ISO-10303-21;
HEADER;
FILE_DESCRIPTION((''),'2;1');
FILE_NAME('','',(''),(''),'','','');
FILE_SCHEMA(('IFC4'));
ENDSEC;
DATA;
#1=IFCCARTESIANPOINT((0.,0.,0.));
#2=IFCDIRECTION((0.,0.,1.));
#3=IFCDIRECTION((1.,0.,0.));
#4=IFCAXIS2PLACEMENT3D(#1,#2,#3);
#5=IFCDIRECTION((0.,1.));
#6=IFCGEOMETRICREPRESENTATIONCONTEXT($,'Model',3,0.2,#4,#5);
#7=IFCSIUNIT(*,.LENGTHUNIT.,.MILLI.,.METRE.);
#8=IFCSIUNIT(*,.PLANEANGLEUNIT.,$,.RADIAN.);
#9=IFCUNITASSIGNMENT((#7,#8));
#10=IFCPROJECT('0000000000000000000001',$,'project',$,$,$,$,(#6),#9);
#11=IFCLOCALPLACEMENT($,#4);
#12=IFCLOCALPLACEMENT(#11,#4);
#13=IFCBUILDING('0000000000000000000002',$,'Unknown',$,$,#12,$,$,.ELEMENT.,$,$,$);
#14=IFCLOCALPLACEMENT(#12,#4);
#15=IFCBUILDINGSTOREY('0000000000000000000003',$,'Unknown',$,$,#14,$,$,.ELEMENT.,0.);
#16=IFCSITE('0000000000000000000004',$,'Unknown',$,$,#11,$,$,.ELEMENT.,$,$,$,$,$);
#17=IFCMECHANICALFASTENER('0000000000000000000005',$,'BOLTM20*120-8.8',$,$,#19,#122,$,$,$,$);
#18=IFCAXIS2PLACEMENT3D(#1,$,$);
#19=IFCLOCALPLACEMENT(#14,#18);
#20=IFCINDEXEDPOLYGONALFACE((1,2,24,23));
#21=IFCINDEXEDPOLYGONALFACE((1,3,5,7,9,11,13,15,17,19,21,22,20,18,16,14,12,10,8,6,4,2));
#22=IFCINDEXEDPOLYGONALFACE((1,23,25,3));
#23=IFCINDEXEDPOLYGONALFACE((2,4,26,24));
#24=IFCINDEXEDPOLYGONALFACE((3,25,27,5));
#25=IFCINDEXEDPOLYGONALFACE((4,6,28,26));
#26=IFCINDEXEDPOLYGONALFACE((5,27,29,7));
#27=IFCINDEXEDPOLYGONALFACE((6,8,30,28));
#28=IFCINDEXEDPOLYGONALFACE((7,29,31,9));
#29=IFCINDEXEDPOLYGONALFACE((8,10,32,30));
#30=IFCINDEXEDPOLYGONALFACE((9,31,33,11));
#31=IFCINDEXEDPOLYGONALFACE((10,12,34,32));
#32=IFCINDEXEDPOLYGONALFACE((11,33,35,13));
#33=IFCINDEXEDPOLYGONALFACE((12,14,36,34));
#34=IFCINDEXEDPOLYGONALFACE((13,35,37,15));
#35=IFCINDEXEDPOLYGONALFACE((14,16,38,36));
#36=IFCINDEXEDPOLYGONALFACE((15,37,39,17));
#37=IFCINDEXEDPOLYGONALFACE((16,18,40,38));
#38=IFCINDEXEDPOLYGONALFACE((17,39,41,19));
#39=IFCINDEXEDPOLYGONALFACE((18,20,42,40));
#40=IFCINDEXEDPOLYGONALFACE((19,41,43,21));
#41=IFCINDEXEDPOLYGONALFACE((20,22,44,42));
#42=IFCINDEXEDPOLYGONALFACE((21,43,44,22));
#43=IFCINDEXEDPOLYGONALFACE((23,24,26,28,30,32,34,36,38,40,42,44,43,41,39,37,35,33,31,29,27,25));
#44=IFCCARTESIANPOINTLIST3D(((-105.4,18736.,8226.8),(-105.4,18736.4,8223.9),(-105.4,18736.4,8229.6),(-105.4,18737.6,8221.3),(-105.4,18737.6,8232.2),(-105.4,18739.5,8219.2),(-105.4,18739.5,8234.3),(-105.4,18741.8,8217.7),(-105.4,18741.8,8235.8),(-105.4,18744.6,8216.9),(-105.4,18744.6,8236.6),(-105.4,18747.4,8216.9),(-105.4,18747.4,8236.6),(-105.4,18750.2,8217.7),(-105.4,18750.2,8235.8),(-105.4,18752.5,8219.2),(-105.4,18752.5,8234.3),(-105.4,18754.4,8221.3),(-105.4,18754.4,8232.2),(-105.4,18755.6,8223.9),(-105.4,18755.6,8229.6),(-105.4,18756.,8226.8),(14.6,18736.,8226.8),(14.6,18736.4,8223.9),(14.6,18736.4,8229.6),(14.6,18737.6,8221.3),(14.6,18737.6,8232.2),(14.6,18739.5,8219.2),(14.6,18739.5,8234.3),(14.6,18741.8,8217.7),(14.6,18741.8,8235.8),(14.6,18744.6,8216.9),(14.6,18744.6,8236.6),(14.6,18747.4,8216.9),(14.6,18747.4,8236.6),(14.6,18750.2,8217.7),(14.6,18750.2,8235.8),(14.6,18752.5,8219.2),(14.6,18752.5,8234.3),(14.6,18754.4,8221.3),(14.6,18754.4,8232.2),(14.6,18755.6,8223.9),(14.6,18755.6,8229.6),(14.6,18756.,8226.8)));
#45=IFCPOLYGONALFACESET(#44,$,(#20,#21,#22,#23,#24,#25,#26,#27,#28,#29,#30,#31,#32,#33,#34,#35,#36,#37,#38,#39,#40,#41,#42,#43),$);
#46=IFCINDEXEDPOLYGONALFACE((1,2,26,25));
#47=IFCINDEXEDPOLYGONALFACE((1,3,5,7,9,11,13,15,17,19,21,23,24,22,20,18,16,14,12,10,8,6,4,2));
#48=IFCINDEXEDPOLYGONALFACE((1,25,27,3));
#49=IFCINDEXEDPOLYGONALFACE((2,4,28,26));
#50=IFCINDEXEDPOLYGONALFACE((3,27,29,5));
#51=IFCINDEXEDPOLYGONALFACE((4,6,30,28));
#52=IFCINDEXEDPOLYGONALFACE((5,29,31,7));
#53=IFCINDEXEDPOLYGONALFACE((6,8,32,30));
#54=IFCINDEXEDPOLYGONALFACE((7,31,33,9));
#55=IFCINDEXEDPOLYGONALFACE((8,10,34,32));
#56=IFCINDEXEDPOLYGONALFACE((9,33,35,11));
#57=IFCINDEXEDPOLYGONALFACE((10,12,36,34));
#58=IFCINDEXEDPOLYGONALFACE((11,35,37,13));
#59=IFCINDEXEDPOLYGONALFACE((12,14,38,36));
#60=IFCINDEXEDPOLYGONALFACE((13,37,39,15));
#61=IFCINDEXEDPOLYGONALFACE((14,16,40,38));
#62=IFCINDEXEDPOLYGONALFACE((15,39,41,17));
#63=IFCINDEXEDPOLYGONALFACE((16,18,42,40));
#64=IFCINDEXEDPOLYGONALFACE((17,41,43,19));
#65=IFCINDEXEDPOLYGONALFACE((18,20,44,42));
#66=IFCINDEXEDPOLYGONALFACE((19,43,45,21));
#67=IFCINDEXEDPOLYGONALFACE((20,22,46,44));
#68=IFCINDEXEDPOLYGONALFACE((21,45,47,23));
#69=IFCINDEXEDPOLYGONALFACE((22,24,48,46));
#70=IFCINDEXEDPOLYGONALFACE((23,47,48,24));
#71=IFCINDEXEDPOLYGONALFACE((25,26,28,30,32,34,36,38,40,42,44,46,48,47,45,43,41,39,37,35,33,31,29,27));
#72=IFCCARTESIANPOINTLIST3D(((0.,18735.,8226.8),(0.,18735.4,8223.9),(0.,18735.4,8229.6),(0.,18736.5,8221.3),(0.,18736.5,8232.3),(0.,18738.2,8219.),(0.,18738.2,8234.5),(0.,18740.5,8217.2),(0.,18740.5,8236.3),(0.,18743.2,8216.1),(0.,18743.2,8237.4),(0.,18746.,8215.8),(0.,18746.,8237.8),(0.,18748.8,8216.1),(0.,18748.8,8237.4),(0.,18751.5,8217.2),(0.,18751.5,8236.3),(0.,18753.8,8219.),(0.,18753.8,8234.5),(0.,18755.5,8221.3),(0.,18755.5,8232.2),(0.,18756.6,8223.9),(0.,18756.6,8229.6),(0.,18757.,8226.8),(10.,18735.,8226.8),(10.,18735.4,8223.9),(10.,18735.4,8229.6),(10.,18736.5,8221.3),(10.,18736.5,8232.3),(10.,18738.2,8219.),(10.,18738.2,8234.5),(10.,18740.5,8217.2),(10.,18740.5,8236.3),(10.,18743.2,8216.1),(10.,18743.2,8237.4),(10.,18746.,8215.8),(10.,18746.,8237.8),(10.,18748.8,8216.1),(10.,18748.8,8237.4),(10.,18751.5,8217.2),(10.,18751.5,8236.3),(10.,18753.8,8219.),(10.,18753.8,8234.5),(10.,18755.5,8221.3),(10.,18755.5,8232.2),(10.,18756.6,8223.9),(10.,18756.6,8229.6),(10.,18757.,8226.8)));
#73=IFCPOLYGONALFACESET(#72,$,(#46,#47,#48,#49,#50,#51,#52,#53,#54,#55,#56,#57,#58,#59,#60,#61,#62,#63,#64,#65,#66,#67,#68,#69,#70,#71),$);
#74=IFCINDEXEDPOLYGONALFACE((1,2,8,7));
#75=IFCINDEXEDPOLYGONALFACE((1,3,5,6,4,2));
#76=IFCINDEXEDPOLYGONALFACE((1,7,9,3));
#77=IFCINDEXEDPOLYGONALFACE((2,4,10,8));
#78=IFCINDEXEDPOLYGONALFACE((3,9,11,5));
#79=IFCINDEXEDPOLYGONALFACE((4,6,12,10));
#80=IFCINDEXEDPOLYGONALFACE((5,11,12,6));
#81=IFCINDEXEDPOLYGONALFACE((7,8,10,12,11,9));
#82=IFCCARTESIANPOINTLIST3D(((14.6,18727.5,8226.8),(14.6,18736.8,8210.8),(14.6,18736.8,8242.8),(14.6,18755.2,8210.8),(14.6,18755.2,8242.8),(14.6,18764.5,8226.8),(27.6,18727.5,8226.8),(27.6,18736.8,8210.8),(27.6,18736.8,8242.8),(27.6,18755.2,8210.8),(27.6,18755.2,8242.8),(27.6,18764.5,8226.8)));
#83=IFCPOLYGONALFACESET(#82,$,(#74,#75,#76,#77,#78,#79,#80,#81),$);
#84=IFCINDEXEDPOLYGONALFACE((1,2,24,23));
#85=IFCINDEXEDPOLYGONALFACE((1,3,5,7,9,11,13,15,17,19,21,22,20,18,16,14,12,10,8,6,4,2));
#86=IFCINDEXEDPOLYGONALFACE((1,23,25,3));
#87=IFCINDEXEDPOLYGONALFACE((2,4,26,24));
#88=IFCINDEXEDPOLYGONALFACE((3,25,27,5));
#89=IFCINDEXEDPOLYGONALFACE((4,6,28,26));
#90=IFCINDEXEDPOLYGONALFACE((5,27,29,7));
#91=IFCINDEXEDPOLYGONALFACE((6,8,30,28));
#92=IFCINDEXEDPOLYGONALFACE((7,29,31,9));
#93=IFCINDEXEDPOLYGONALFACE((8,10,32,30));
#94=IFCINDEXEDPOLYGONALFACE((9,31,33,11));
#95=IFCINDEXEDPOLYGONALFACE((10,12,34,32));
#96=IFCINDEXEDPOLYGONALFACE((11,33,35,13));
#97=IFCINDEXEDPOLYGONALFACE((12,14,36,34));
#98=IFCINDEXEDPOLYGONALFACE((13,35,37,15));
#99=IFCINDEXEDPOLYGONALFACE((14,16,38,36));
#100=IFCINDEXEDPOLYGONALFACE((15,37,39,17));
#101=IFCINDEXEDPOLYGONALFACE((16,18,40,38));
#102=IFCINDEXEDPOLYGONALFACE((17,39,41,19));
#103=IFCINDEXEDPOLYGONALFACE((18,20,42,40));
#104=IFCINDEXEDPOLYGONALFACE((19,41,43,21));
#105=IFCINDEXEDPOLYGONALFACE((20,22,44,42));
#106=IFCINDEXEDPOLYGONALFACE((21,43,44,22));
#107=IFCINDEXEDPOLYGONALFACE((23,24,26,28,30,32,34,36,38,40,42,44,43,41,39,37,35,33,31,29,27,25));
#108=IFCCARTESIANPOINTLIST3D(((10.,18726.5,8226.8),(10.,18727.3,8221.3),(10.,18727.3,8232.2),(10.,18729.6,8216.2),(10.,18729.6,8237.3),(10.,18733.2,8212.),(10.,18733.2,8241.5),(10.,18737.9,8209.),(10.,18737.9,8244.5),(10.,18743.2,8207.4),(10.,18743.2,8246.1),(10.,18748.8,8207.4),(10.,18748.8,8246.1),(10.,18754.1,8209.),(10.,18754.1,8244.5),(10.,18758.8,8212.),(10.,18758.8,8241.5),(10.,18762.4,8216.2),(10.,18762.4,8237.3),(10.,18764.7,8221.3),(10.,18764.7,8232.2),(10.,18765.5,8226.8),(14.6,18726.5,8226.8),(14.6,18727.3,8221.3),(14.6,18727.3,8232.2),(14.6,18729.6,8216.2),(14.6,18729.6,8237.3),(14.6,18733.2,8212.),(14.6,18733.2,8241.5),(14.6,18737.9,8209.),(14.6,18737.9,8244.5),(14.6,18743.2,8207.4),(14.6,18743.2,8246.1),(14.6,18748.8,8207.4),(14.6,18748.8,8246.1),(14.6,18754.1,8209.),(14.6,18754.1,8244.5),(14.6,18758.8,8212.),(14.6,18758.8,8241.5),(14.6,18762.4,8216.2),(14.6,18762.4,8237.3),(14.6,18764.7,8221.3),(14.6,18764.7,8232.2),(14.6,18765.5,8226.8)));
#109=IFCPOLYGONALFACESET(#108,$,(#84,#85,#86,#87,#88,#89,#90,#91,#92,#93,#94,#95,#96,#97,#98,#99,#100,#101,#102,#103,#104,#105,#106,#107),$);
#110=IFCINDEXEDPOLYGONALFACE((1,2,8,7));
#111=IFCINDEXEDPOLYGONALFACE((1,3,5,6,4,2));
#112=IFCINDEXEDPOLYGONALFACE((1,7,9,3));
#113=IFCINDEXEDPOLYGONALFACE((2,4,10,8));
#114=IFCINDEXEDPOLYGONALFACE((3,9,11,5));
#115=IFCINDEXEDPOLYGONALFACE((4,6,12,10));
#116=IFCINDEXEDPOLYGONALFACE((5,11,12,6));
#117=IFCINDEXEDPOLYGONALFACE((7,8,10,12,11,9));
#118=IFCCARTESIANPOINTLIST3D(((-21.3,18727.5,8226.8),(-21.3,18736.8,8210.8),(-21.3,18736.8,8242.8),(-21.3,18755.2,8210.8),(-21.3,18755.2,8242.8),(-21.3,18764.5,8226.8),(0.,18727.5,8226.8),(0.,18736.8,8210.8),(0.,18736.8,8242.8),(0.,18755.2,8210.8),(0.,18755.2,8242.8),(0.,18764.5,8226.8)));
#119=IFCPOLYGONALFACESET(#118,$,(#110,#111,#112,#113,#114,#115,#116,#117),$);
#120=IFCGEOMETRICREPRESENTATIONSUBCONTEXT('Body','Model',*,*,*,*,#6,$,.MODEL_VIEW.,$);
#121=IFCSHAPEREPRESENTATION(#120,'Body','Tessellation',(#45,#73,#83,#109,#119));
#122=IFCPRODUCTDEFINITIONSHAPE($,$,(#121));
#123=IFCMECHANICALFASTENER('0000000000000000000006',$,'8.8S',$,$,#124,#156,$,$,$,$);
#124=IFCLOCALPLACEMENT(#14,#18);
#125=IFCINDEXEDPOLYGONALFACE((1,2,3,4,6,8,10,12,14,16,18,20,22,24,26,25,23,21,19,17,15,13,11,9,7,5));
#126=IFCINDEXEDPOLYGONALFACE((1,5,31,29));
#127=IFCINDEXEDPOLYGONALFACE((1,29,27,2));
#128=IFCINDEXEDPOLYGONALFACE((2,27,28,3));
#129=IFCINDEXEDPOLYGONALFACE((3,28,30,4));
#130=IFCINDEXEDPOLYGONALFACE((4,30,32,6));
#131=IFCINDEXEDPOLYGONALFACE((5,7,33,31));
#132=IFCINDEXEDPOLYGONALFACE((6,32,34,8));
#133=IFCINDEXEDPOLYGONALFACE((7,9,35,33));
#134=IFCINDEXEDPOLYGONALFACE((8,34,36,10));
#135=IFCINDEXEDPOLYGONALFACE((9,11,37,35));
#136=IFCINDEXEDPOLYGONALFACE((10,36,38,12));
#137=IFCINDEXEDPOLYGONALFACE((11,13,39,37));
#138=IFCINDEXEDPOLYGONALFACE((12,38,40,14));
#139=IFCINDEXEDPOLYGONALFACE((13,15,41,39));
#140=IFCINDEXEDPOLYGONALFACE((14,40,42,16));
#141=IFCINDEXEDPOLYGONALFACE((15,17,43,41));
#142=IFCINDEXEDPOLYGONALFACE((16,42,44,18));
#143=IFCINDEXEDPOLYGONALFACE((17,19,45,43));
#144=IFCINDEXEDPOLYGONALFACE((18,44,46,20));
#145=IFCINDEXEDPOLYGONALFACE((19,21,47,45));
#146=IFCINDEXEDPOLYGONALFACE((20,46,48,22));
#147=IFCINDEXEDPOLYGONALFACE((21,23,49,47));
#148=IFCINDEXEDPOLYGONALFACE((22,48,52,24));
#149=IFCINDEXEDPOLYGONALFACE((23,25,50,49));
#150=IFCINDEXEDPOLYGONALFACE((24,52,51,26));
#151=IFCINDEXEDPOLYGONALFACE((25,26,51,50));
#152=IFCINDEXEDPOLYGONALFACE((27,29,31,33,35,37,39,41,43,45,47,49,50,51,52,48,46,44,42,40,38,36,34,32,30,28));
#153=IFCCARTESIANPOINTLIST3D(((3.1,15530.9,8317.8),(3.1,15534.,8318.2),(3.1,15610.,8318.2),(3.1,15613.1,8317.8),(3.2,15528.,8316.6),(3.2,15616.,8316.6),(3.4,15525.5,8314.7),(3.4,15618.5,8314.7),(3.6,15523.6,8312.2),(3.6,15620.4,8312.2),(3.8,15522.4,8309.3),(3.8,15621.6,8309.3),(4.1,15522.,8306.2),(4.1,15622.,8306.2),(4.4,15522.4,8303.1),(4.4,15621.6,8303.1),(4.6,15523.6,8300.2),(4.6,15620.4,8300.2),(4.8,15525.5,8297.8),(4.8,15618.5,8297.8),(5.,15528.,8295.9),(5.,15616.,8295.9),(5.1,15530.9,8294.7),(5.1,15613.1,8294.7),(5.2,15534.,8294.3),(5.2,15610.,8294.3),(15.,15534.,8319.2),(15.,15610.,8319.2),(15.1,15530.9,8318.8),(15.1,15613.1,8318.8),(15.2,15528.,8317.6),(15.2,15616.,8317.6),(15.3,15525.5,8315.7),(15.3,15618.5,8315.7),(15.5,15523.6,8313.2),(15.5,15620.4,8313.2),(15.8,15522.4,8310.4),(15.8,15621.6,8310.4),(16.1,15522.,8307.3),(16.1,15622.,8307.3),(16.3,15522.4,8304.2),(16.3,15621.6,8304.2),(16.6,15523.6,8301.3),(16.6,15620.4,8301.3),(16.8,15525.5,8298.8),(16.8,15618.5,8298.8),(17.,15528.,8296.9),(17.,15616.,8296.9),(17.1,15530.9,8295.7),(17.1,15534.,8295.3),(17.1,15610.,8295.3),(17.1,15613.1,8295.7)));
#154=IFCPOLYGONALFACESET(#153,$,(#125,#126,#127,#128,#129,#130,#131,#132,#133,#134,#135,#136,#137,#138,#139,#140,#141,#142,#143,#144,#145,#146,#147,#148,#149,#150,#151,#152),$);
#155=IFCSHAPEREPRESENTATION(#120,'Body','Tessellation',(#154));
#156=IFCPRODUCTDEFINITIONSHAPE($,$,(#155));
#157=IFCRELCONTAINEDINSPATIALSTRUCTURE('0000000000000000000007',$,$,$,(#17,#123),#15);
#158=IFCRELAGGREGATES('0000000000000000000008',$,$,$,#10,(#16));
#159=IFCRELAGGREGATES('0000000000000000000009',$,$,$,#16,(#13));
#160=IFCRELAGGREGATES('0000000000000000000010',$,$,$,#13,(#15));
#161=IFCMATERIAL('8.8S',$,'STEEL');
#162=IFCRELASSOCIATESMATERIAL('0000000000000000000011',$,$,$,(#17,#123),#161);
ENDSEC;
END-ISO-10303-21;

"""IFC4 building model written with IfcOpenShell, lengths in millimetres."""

from ifc_helpers import new_model, si_unit, direction, frame, origin_with_axes, place, context, subcontext, project, spatial, line, arc, indexed_curve, outline, extrude, source, transform, mapped, material, element, save


model = new_model("IFC4")

# Units and contexts
model_context = context("Model", 3, precision=0.2, world=origin_with_axes(), true_north=direction((0.0, 1.0)))
body_context = subcontext(model_context, "Body", "Model", "MODEL_VIEW")
ifc_project = project(units=[si_unit("LENGTHUNIT", "METRE", prefix="MILLI"), si_unit("PLANEANGLEUNIT", "RADIAN")], contexts=[model_context])

# Site, building, storey
site_placement = place(None, origin_with_axes())
site = spatial("IfcSite", under=ifc_project, at=site_placement, Name="Unknown", CompositionType="ELEMENT")
building_placement = place(site_placement, origin_with_axes())
building = spatial("IfcBuilding", under=site, at=building_placement, Name="Unknown", CompositionType="ELEMENT")
storey_placement = place(building_placement, origin_with_axes())
storey = spatial("IfcBuildingStorey", under=building, at=storey_placement, Name="Unknown", CompositionType="ELEMENT", Elevation=0.0)

# Mechanical fasteners
ifc_material_1 = material(Name="8.8S", Category="STEEL")
shared_shape_1 = source(origin_with_axes(), body_context, "Body", "SweptSolid", [
    extrude(outline(indexed_curve([(10.0, 0.0), (0.0, 10.0), (-10.0, 0.0), (0.0, -10.0)], segments=[arc(1, 2, 3), arc(3, 4, 1)])), frame((0.0, 0.0, 4.6), z_axis=(0.0, 0.0, -1.0), x_axis=(0.0, 1.0, 0.0)), (0.0, 0.0, 1.0), 120.0),
    extrude(outline(indexed_curve([(0.0, 11.0), (7.8, 7.8), (11.0, 0.0), (7.8, -7.8), (0.0, -11.0), (-1.0, -11.0), (-11.0, 0.0), (-7.8, 7.8)], segments=[arc(1, 2, 3), arc(3, 4, 5), arc(5, 6, 7), arc(7, 8, 1)])), frame((0.0, 0.0, 0.0), z_axis=(0.0, 0.0, -1.0), x_axis=(0.0, 1.0, 0.0)), (0.0, 0.0, 1.0), 10.0),
    extrude(outline(indexed_curve([(18.5, 0.0), (9.2, 16.0), (-9.2, 16.0), (-18.5, 0.0), (-9.2, -16.0), (9.2, -16.0)], segments=[line(1, 2, 3, 4, 5, 6, 1)])), frame((0.0, 0.0, 17.6), z_axis=(0.0, 0.0, -1.0), x_axis=(0.0, 1.0, 0.0)), (0.0, 0.0, 1.0), 13.0),
    extrude(outline(indexed_curve([(19.5, 0.0), (0.0, 19.5), (-19.5, 0.0), (0.0, -19.5)], segments=[arc(1, 2, 3), arc(3, 4, 1)])), frame((0.0, 0.0, 4.6), z_axis=(0.0, 0.0, -1.0), x_axis=(0.0, 1.0, 0.0)), (0.0, 0.0, 1.0), 4.6),
    extrude(outline(indexed_curve([(18.5, 0.0), (9.2, 16.0), (-9.2, 16.0), (-18.5, 0.0), (-9.2, -16.0), (9.2, -16.0)], segments=[line(1, 2, 3, 4, 5, 6, 1)])), frame((0.0, 0.0, -10.0), z_axis=(0.0, 0.0, -1.0), x_axis=(0.0, 1.0, 0.0)), (0.0, 0.0, 1.0), 21.3),
])
mechanical_fastener_1_placement = place(storey_placement, frame((10.0, 18746.0, 8226.8), z_axis=(1.0, 0.0, 0.0), x_axis=(0.0, 0.0, -1.0)))
element("IfcMechanicalFastener", 1, at=mechanical_fastener_1_placement, inside=storey, material=ifc_material_1, Name="BOLTM20*120-8.8", context=body_context, shape_type="MappedRepresentation", body=[
    mapped(shared_shape_1, transform((0.0, 0.0, 0.0))),
])
shared_shape_2 = source(origin_with_axes(), body_context, "Body", "SweptSolid", [
    extrude(outline(indexed_curve([(0.0, 50.0), (8.5, 46.5), (12.0, 38.0), (12.0, -38.0), (8.5, -46.5), (0.0, -50.0), (-1.1, -50.0), (-12.0, -38.0), (-12.0, 38.0), (-8.5, 46.5)], segments=[arc(1, 2, 3), line(3, 4), arc(4, 5, 6), arc(6, 7, 8), line(8, 9), arc(9, 10, 1)])), frame((0.0, 0.0, 0.0), z_axis=(0.0, 0.0, -1.0), x_axis=(0.0, 1.0, 0.0)), (0.0, 0.0, 1.0), 12.0),
])
mechanical_fastener_2_placement = place(storey_placement, frame((16.1, 15572.0, 8307.3), z_axis=(0.996195, 0.0, 0.087156), x_axis=(0.0, 1.0, 0.0)))
element("IfcMechanicalFastener", 2, at=mechanical_fastener_2_placement, inside=storey, material=ifc_material_1, Name="8.8S", context=body_context, shape_type="MappedRepresentation", body=[
    mapped(shared_shape_2, transform((0.0, 0.0, 0.0))),
])

save(model, "model.ifc")
